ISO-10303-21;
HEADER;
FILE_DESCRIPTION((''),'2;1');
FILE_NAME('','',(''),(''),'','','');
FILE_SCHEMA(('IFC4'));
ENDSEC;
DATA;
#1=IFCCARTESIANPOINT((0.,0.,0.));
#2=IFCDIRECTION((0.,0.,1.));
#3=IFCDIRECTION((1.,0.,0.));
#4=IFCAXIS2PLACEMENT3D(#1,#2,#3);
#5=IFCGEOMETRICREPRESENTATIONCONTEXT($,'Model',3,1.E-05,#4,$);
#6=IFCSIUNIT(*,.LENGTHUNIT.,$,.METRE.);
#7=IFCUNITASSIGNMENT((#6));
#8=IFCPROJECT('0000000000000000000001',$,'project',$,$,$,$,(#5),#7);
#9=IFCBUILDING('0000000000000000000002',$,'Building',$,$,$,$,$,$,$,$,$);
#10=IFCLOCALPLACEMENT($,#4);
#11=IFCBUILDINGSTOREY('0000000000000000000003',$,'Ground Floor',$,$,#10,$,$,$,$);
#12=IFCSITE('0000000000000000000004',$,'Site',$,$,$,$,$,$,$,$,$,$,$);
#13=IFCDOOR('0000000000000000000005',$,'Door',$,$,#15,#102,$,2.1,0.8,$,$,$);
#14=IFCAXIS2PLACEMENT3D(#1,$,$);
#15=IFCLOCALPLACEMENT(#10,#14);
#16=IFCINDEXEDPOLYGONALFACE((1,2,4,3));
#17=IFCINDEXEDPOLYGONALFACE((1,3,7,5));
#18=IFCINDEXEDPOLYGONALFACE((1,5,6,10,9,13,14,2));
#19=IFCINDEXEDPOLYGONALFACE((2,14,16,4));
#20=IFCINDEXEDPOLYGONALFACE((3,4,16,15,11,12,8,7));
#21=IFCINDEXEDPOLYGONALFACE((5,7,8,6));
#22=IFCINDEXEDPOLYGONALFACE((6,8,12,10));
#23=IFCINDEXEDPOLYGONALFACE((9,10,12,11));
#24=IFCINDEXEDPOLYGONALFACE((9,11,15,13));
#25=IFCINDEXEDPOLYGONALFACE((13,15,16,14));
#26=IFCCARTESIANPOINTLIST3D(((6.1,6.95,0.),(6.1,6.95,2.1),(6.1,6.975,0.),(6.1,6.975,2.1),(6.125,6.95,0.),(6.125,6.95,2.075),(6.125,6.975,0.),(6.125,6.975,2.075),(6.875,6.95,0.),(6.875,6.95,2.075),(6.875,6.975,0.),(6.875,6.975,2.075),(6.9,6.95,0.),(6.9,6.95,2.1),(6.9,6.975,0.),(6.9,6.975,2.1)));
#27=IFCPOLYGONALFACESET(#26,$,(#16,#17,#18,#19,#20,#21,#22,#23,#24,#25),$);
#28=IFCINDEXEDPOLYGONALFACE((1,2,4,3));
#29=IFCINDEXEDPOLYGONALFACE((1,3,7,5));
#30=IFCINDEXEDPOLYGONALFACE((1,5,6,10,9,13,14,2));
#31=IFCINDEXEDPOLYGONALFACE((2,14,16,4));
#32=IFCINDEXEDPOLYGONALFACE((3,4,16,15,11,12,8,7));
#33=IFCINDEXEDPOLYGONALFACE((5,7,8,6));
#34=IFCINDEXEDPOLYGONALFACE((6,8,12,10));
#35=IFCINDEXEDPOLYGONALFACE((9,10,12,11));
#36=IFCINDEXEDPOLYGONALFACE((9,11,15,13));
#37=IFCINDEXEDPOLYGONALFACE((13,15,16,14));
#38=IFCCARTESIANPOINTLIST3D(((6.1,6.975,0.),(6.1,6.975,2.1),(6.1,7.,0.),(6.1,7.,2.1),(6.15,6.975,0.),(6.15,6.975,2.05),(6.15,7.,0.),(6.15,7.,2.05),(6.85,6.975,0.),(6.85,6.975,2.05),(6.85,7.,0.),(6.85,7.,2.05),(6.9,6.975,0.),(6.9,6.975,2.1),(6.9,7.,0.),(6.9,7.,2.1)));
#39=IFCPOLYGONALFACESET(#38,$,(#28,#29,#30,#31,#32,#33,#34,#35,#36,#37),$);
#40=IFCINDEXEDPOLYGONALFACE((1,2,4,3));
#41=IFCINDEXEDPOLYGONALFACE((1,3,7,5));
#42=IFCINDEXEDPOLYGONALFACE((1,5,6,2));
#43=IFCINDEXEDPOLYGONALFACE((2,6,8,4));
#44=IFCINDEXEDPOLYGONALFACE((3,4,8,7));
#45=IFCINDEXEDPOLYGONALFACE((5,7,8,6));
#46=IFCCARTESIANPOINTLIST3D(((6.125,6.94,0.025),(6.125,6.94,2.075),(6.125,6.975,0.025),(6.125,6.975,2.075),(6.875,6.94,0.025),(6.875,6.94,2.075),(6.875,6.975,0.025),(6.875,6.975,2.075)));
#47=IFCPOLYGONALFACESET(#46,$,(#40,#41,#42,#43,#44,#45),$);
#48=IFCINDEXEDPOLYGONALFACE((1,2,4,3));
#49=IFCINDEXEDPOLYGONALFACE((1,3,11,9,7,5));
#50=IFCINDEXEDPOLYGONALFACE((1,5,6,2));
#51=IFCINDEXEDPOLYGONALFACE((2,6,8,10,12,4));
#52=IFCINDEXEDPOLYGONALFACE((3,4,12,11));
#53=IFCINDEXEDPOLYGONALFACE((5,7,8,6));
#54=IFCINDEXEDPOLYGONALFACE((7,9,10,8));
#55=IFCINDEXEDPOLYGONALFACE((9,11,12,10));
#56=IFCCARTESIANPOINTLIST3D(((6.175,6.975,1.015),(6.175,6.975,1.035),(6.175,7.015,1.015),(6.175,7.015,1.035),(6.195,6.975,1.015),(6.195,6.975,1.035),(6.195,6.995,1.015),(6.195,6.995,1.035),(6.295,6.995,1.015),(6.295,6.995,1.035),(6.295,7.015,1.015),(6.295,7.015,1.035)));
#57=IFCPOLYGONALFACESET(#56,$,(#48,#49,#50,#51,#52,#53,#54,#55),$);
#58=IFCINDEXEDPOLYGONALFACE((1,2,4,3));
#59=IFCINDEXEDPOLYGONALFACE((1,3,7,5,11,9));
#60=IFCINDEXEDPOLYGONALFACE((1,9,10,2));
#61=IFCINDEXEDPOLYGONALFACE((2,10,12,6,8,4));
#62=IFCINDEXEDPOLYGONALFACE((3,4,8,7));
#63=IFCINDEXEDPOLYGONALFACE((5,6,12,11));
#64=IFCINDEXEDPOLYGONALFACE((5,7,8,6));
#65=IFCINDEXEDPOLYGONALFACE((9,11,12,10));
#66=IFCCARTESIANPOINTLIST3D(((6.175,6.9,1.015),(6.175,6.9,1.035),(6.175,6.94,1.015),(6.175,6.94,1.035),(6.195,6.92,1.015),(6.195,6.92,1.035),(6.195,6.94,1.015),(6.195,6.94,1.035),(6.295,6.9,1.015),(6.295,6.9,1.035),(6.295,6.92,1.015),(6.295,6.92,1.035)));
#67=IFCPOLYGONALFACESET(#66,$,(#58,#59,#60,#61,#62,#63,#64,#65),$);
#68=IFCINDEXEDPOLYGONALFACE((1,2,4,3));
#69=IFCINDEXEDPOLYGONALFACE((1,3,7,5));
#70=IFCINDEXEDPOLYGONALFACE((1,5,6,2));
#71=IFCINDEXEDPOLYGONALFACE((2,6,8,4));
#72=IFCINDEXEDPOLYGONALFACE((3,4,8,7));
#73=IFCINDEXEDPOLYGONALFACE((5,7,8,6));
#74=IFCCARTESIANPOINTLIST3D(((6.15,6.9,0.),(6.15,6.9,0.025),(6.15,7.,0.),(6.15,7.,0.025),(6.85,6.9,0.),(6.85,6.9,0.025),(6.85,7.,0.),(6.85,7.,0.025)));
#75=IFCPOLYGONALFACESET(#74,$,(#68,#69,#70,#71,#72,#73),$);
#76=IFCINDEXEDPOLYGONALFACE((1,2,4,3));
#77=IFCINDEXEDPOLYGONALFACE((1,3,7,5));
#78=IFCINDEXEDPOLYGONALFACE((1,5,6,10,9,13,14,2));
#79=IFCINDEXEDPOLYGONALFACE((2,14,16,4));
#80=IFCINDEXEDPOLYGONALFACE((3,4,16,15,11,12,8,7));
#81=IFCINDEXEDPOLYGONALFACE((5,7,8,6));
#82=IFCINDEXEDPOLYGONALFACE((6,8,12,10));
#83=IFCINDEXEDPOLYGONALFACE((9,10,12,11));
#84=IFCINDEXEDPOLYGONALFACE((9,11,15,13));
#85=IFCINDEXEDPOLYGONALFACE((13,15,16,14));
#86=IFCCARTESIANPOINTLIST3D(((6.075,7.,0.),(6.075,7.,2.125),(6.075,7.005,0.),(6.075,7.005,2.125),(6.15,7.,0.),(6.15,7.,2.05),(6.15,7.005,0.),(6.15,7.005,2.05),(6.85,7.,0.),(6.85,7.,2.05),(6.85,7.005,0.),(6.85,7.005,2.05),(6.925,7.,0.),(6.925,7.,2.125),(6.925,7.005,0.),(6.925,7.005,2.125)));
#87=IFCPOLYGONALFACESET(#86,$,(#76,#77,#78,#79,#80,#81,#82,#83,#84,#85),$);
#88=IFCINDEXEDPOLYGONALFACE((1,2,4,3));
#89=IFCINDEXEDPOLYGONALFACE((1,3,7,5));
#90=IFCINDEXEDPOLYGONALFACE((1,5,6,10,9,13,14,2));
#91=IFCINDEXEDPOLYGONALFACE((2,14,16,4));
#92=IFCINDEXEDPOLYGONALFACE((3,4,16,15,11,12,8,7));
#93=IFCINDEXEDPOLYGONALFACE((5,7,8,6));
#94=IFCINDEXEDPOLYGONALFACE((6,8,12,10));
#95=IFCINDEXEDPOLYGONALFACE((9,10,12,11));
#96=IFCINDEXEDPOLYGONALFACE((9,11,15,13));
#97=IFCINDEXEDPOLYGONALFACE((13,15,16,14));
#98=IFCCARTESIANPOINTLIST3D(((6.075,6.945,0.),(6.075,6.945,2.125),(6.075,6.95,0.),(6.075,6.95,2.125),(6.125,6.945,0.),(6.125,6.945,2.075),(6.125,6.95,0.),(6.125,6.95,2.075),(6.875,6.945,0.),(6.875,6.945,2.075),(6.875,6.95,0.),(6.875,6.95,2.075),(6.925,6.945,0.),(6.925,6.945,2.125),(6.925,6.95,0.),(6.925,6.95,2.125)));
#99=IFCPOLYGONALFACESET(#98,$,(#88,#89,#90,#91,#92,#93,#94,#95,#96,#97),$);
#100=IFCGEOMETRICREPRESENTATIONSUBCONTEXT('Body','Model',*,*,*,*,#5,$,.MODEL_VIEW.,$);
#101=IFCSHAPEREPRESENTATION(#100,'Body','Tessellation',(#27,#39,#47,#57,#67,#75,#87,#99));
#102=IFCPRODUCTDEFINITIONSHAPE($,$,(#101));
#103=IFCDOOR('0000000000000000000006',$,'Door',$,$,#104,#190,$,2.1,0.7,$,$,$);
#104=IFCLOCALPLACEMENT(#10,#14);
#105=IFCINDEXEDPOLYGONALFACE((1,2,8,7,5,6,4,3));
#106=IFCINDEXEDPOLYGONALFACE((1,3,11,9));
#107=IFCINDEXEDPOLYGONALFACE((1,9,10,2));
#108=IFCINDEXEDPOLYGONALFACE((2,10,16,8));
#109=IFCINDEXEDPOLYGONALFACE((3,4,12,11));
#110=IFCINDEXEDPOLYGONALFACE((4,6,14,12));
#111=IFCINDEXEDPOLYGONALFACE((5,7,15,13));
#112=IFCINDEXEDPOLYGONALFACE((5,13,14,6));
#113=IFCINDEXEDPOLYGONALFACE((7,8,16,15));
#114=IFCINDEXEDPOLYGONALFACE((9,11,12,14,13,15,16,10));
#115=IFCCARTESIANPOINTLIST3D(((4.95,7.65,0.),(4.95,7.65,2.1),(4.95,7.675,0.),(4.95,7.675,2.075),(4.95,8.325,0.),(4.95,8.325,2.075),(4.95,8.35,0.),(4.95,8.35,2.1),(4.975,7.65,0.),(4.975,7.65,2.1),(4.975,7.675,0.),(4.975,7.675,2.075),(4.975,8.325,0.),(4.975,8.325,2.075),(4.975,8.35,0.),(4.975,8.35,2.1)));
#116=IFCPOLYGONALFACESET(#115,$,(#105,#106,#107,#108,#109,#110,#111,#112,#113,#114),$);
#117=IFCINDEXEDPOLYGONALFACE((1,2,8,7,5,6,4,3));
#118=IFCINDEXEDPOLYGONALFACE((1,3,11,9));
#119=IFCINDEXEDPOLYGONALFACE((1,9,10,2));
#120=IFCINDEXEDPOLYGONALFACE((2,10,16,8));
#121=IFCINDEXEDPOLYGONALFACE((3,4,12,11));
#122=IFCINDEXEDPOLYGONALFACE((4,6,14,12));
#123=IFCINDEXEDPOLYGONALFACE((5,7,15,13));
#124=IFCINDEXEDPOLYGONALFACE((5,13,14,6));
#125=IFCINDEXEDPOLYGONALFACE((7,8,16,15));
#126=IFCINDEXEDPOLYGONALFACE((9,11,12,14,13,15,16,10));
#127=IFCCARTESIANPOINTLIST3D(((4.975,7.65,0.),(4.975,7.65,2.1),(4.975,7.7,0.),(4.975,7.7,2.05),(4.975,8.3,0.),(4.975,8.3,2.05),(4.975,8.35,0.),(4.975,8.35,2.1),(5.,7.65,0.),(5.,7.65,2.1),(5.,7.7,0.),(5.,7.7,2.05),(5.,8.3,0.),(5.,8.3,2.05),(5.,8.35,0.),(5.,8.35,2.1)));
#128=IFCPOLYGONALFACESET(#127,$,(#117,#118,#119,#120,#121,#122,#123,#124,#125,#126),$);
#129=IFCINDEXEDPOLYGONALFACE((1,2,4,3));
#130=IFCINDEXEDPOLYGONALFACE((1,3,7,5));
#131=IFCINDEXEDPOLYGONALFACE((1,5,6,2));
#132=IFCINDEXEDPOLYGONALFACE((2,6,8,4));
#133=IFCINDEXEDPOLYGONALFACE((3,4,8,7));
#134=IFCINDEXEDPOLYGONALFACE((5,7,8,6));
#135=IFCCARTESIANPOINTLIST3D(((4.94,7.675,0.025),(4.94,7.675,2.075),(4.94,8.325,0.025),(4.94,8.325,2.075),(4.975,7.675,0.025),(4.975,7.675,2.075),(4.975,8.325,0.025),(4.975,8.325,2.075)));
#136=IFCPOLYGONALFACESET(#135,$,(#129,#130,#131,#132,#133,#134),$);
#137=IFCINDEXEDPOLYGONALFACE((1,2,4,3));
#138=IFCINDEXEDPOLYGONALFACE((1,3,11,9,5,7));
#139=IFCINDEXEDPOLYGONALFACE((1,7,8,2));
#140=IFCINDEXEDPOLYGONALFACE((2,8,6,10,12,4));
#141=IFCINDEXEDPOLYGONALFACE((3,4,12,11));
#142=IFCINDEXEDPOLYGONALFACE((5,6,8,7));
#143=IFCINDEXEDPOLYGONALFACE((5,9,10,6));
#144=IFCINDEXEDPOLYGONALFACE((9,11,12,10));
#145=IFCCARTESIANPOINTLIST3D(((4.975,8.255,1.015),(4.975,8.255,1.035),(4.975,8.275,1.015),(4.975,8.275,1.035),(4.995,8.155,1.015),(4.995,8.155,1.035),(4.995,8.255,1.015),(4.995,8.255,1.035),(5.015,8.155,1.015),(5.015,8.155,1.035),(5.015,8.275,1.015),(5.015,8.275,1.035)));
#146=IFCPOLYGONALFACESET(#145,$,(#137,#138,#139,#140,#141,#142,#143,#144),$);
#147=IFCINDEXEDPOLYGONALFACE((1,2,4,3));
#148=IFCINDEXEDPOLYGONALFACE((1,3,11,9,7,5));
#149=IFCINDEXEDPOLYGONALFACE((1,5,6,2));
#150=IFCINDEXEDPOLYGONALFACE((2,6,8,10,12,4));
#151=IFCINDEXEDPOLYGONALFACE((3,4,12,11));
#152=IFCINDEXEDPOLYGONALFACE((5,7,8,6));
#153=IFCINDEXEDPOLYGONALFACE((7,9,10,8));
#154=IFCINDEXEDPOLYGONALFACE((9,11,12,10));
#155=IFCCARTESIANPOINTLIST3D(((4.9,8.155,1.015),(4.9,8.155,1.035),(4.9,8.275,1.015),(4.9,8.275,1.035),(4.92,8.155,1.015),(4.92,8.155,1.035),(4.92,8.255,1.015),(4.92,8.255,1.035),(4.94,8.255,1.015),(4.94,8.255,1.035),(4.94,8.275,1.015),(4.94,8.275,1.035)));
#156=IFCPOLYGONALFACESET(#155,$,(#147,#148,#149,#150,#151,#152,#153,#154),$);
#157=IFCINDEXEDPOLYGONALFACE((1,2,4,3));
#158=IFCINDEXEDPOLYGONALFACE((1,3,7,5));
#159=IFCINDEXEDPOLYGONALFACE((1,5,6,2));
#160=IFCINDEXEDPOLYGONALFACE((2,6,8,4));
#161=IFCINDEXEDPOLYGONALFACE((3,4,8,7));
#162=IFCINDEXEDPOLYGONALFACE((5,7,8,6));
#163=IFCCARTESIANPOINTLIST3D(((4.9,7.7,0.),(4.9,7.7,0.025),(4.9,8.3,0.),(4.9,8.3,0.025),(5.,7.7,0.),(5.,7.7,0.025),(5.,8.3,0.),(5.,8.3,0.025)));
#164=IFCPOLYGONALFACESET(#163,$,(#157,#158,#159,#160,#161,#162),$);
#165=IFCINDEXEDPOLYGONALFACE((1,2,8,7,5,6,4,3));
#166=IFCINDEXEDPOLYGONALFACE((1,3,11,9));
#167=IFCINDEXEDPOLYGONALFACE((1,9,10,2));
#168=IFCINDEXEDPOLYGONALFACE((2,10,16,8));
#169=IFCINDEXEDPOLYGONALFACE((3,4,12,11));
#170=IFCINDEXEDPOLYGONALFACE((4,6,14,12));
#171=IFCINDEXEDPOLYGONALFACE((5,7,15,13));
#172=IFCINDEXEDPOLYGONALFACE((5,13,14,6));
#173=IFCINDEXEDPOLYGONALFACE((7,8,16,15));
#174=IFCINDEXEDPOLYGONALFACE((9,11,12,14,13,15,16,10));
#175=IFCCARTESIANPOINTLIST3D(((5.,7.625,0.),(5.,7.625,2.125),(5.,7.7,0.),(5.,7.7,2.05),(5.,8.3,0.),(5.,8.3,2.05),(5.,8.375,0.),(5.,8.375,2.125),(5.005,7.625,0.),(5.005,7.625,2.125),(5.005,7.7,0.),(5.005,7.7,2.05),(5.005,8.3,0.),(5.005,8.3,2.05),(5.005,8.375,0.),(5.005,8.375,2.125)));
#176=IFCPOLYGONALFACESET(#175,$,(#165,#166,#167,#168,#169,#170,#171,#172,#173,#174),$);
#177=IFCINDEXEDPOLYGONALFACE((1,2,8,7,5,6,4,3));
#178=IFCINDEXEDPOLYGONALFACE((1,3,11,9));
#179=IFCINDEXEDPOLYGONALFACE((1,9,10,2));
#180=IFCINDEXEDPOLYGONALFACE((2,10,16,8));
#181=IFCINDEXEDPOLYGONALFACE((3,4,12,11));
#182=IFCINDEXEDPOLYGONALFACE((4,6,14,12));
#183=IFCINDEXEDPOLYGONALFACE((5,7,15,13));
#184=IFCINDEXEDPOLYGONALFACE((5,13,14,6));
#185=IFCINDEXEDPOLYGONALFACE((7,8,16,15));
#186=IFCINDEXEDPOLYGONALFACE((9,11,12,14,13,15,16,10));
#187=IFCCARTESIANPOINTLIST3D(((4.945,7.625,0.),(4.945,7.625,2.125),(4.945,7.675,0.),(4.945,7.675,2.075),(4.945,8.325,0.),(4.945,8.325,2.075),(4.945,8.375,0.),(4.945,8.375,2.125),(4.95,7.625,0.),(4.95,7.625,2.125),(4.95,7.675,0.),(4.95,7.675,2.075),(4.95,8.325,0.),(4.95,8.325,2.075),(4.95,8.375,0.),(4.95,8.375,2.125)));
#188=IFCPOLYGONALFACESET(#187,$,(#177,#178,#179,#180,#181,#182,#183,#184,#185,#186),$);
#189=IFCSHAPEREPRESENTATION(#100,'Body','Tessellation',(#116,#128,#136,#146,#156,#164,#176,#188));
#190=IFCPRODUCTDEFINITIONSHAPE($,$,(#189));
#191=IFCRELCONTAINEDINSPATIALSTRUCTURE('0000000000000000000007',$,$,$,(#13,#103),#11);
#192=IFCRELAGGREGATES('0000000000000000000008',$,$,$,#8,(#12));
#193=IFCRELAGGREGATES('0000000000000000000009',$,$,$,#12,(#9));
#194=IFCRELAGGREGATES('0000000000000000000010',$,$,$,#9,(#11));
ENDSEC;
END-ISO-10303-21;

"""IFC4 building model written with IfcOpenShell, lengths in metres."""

from ifc_helpers import new_model, si_unit, frame, origin_with_axes, place, context, subcontext, project, spatial, line, indexed_curve, outline, extrude, element, save


model = new_model("IFC4")

# Units and contexts
model_context = context("Model", 3, precision=1e-05, world=origin_with_axes())
body_context = subcontext(model_context, "Body", "Model", "MODEL_VIEW")
ifc_project = project(units=[si_unit("LENGTHUNIT", "METRE")], contexts=[model_context])

# Site, building, storey
site = spatial("IfcSite", under=ifc_project, Name="Site")
building = spatial("IfcBuilding", under=site, Name="Building")
storey_placement = place(None, origin_with_axes())
storey = spatial("IfcBuildingStorey", under=building, at=storey_placement, Name="Ground Floor")

# Doors
door_1_placement = place(storey_placement, frame((6.9, 7.0, 0.0), z_axis=(0.0, 0.0, 1.0), x_axis=(-1.0, 0.0, 0.0)))
element("IfcDoor", 1, at=door_1_placement, inside=storey, Name="Door", OverallHeight=2.1, OverallWidth=0.8, context=body_context, shape_type="SweptSolid", body=[
    extrude(outline(indexed_curve([(0.0, 0.0), (0.0, 2.1), (0.8, 2.1), (0.8, 0.0), (0.775, 0.0), (0.775, 2.075), (0.025, 2.075), (0.025, 0.0)], segments=[line(1, 2, 3, 4, 5, 6, 7, 8, 1)])), frame((0.0, 0.025, 0.0), z_axis=(0.0, -1.0, 0.0), x_axis=(1.0, 0.0, 0.0)), (0.0, 0.0, -1.0), 0.025),
    extrude(outline(indexed_curve([(0.0, 0.0), (0.0, 2.1), (0.8, 2.1), (0.8, 0.0), (0.75, 0.0), (0.75, 2.05), (0.05, 2.05), (0.05, 0.0)], segments=[line(1, 2, 3, 4, 5, 6, 7, 8, 1)])), frame((0.0, 0.0, 0.0), z_axis=(0.0, -1.0, 0.0), x_axis=(1.0, 0.0, 0.0)), (0.0, 0.0, -1.0), 0.025),
    extrude(outline(indexed_curve([(0.0, 0.0), (0.75, 0.0), (0.75, 0.035), (0.0, 0.035)], segments=[line(1, 2, 3, 4, 1)])), frame((0.025, 0.025, 0.025), z_axis=(0.0, 0.0, 1.0), x_axis=(1.0, 0.0, 0.0)), (0.0, 0.0, 1.0), 2.05),
    extrude(outline(indexed_curve([(0.0, 0.0), (0.0, -0.04), (-0.12, -0.04), (-0.12, -0.02), (-0.02, -0.02), (-0.02, 0.0)], segments=[line(1, 2, 3, 4, 5, 6, 1)])), frame((0.725, 0.025, 1.015), z_axis=(0.0, 0.0, 1.0), x_axis=(1.0, 0.0, 0.0)), (0.0, 0.0, 1.0), 0.02),
    extrude(outline(indexed_curve([(0.0, 0.0), (0.0, 0.04), (-0.12, 0.04), (-0.12, 0.02), (-0.02, 0.02), (-0.02, 0.0)], segments=[line(1, 2, 3, 4, 5, 6, 1)])), frame((0.725, 0.06, 1.015), z_axis=(0.0, 0.0, 1.0), x_axis=(1.0, 0.0, 0.0)), (0.0, 0.0, 1.0), 0.02),
    extrude(outline(indexed_curve([(0.0, 0.0), (0.7, 0.0), (0.7, 0.1), (0.0, 0.1)], segments=[line(1, 2, 3, 4, 1)])), frame((0.05, 0.0, 0.0), z_axis=(0.0, 0.0, 1.0), x_axis=(1.0, 0.0, 0.0)), (0.0, 0.0, 1.0), 0.025),
    extrude(outline(indexed_curve([(0.0, 0.0), (0.0, 2.125), (0.85, 2.125), (0.85, 0.0), (0.775, 0.0), (0.775, 2.05), (0.075, 2.05), (0.075, 0.0)], segments=[line(1, 2, 3, 4, 5, 6, 7, 8, 1)])), frame((-0.025, -0.005, 0.0), z_axis=(0.0, -1.0, 0.0), x_axis=(1.0, 0.0, 0.0)), (0.0, 0.0, -1.0), 0.005),
    extrude(outline(indexed_curve([(0.0, 0.0), (0.0, 2.125), (0.85, 2.125), (0.85, 0.0), (0.8, 0.0), (0.8, 2.075), (0.05, 2.075), (0.05, 0.0)], segments=[line(1, 2, 3, 4, 5, 6, 7, 8, 1)])), frame((-0.025, 0.05, 0.0), z_axis=(0.0, -1.0, 0.0), x_axis=(1.0, 0.0, 0.0)), (0.0, 0.0, -1.0), 0.005),
])
door_2_placement = place(storey_placement, frame((5.0, 7.65, 0.0), z_axis=(0.0, 0.0, 1.0), x_axis=(0.0, 1.0, 0.0)))
element("IfcDoor", 2, at=door_2_placement, inside=storey, Name="Door", OverallHeight=2.1, OverallWidth=0.7, context=body_context, shape_type="SweptSolid", body=[
    extrude(outline(indexed_curve([(0.0, 0.0), (0.0, 2.1), (0.7, 2.1), (0.7, 0.0), (0.675, 0.0), (0.675, 2.075), (0.025, 2.075), (0.025, 0.0)], segments=[line(1, 2, 3, 4, 5, 6, 7, 8, 1)])), frame((0.0, 0.025, 0.0), z_axis=(0.0, -1.0, 0.0), x_axis=(1.0, 0.0, 0.0)), (0.0, 0.0, -1.0), 0.025),
    extrude(outline(indexed_curve([(0.0, 0.0), (0.0, 2.1), (0.7, 2.1), (0.7, 0.0), (0.65, 0.0), (0.65, 2.05), (0.05, 2.05), (0.05, 0.0)], segments=[line(1, 2, 3, 4, 5, 6, 7, 8, 1)])), frame((0.0, 0.0, 0.0), z_axis=(0.0, -1.0, 0.0), x_axis=(1.0, 0.0, 0.0)), (0.0, 0.0, -1.0), 0.025),
    extrude(outline(indexed_curve([(0.0, 0.0), (0.65, 0.0), (0.65, 0.035), (0.0, 0.035)], segments=[line(1, 2, 3, 4, 1)])), frame((0.025, 0.025, 0.025), z_axis=(0.0, 0.0, 1.0), x_axis=(1.0, 0.0, 0.0)), (0.0, 0.0, 1.0), 2.05),
    extrude(outline(indexed_curve([(0.0, 0.0), (0.0, -0.04), (-0.12, -0.04), (-0.12, -0.02), (-0.02, -0.02), (-0.02, 0.0)], segments=[line(1, 2, 3, 4, 5, 6, 1)])), frame((0.625, 0.025, 1.015), z_axis=(0.0, 0.0, 1.0), x_axis=(1.0, 0.0, 0.0)), (0.0, 0.0, 1.0), 0.02),
    extrude(outline(indexed_curve([(0.0, 0.0), (0.0, 0.04), (-0.12, 0.04), (-0.12, 0.02), (-0.02, 0.02), (-0.02, 0.0)], segments=[line(1, 2, 3, 4, 5, 6, 1)])), frame((0.625, 0.06, 1.015), z_axis=(0.0, 0.0, 1.0), x_axis=(1.0, 0.0, 0.0)), (0.0, 0.0, 1.0), 0.02),
    extrude(outline(indexed_curve([(0.0, 0.0), (0.6, 0.0), (0.6, 0.1), (0.0, 0.1)], segments=[line(1, 2, 3, 4, 1)])), frame((0.05, 0.0, 0.0), z_axis=(0.0, 0.0, 1.0), x_axis=(1.0, 0.0, 0.0)), (0.0, 0.0, 1.0), 0.025),
    extrude(outline(indexed_curve([(0.0, 0.0), (0.0, 2.125), (0.75, 2.125), (0.75, 0.0), (0.675, 0.0), (0.675, 2.05), (0.075, 2.05), (0.075, 0.0)], segments=[line(1, 2, 3, 4, 5, 6, 7, 8, 1)])), frame((-0.025, -0.005, 0.0), z_axis=(0.0, -1.0, 0.0), x_axis=(1.0, 0.0, 0.0)), (0.0, 0.0, -1.0), 0.005),
    extrude(outline(indexed_curve([(0.0, 0.0), (0.0, 2.125), (0.75, 2.125), (0.75, 0.0), (0.7, 0.0), (0.7, 2.075), (0.05, 2.075), (0.05, 0.0)], segments=[line(1, 2, 3, 4, 5, 6, 7, 8, 1)])), frame((-0.025, 0.05, 0.0), z_axis=(0.0, -1.0, 0.0), x_axis=(1.0, 0.0, 0.0)), (0.0, 0.0, -1.0), 0.005),
])

save(model, "model.ifc")
